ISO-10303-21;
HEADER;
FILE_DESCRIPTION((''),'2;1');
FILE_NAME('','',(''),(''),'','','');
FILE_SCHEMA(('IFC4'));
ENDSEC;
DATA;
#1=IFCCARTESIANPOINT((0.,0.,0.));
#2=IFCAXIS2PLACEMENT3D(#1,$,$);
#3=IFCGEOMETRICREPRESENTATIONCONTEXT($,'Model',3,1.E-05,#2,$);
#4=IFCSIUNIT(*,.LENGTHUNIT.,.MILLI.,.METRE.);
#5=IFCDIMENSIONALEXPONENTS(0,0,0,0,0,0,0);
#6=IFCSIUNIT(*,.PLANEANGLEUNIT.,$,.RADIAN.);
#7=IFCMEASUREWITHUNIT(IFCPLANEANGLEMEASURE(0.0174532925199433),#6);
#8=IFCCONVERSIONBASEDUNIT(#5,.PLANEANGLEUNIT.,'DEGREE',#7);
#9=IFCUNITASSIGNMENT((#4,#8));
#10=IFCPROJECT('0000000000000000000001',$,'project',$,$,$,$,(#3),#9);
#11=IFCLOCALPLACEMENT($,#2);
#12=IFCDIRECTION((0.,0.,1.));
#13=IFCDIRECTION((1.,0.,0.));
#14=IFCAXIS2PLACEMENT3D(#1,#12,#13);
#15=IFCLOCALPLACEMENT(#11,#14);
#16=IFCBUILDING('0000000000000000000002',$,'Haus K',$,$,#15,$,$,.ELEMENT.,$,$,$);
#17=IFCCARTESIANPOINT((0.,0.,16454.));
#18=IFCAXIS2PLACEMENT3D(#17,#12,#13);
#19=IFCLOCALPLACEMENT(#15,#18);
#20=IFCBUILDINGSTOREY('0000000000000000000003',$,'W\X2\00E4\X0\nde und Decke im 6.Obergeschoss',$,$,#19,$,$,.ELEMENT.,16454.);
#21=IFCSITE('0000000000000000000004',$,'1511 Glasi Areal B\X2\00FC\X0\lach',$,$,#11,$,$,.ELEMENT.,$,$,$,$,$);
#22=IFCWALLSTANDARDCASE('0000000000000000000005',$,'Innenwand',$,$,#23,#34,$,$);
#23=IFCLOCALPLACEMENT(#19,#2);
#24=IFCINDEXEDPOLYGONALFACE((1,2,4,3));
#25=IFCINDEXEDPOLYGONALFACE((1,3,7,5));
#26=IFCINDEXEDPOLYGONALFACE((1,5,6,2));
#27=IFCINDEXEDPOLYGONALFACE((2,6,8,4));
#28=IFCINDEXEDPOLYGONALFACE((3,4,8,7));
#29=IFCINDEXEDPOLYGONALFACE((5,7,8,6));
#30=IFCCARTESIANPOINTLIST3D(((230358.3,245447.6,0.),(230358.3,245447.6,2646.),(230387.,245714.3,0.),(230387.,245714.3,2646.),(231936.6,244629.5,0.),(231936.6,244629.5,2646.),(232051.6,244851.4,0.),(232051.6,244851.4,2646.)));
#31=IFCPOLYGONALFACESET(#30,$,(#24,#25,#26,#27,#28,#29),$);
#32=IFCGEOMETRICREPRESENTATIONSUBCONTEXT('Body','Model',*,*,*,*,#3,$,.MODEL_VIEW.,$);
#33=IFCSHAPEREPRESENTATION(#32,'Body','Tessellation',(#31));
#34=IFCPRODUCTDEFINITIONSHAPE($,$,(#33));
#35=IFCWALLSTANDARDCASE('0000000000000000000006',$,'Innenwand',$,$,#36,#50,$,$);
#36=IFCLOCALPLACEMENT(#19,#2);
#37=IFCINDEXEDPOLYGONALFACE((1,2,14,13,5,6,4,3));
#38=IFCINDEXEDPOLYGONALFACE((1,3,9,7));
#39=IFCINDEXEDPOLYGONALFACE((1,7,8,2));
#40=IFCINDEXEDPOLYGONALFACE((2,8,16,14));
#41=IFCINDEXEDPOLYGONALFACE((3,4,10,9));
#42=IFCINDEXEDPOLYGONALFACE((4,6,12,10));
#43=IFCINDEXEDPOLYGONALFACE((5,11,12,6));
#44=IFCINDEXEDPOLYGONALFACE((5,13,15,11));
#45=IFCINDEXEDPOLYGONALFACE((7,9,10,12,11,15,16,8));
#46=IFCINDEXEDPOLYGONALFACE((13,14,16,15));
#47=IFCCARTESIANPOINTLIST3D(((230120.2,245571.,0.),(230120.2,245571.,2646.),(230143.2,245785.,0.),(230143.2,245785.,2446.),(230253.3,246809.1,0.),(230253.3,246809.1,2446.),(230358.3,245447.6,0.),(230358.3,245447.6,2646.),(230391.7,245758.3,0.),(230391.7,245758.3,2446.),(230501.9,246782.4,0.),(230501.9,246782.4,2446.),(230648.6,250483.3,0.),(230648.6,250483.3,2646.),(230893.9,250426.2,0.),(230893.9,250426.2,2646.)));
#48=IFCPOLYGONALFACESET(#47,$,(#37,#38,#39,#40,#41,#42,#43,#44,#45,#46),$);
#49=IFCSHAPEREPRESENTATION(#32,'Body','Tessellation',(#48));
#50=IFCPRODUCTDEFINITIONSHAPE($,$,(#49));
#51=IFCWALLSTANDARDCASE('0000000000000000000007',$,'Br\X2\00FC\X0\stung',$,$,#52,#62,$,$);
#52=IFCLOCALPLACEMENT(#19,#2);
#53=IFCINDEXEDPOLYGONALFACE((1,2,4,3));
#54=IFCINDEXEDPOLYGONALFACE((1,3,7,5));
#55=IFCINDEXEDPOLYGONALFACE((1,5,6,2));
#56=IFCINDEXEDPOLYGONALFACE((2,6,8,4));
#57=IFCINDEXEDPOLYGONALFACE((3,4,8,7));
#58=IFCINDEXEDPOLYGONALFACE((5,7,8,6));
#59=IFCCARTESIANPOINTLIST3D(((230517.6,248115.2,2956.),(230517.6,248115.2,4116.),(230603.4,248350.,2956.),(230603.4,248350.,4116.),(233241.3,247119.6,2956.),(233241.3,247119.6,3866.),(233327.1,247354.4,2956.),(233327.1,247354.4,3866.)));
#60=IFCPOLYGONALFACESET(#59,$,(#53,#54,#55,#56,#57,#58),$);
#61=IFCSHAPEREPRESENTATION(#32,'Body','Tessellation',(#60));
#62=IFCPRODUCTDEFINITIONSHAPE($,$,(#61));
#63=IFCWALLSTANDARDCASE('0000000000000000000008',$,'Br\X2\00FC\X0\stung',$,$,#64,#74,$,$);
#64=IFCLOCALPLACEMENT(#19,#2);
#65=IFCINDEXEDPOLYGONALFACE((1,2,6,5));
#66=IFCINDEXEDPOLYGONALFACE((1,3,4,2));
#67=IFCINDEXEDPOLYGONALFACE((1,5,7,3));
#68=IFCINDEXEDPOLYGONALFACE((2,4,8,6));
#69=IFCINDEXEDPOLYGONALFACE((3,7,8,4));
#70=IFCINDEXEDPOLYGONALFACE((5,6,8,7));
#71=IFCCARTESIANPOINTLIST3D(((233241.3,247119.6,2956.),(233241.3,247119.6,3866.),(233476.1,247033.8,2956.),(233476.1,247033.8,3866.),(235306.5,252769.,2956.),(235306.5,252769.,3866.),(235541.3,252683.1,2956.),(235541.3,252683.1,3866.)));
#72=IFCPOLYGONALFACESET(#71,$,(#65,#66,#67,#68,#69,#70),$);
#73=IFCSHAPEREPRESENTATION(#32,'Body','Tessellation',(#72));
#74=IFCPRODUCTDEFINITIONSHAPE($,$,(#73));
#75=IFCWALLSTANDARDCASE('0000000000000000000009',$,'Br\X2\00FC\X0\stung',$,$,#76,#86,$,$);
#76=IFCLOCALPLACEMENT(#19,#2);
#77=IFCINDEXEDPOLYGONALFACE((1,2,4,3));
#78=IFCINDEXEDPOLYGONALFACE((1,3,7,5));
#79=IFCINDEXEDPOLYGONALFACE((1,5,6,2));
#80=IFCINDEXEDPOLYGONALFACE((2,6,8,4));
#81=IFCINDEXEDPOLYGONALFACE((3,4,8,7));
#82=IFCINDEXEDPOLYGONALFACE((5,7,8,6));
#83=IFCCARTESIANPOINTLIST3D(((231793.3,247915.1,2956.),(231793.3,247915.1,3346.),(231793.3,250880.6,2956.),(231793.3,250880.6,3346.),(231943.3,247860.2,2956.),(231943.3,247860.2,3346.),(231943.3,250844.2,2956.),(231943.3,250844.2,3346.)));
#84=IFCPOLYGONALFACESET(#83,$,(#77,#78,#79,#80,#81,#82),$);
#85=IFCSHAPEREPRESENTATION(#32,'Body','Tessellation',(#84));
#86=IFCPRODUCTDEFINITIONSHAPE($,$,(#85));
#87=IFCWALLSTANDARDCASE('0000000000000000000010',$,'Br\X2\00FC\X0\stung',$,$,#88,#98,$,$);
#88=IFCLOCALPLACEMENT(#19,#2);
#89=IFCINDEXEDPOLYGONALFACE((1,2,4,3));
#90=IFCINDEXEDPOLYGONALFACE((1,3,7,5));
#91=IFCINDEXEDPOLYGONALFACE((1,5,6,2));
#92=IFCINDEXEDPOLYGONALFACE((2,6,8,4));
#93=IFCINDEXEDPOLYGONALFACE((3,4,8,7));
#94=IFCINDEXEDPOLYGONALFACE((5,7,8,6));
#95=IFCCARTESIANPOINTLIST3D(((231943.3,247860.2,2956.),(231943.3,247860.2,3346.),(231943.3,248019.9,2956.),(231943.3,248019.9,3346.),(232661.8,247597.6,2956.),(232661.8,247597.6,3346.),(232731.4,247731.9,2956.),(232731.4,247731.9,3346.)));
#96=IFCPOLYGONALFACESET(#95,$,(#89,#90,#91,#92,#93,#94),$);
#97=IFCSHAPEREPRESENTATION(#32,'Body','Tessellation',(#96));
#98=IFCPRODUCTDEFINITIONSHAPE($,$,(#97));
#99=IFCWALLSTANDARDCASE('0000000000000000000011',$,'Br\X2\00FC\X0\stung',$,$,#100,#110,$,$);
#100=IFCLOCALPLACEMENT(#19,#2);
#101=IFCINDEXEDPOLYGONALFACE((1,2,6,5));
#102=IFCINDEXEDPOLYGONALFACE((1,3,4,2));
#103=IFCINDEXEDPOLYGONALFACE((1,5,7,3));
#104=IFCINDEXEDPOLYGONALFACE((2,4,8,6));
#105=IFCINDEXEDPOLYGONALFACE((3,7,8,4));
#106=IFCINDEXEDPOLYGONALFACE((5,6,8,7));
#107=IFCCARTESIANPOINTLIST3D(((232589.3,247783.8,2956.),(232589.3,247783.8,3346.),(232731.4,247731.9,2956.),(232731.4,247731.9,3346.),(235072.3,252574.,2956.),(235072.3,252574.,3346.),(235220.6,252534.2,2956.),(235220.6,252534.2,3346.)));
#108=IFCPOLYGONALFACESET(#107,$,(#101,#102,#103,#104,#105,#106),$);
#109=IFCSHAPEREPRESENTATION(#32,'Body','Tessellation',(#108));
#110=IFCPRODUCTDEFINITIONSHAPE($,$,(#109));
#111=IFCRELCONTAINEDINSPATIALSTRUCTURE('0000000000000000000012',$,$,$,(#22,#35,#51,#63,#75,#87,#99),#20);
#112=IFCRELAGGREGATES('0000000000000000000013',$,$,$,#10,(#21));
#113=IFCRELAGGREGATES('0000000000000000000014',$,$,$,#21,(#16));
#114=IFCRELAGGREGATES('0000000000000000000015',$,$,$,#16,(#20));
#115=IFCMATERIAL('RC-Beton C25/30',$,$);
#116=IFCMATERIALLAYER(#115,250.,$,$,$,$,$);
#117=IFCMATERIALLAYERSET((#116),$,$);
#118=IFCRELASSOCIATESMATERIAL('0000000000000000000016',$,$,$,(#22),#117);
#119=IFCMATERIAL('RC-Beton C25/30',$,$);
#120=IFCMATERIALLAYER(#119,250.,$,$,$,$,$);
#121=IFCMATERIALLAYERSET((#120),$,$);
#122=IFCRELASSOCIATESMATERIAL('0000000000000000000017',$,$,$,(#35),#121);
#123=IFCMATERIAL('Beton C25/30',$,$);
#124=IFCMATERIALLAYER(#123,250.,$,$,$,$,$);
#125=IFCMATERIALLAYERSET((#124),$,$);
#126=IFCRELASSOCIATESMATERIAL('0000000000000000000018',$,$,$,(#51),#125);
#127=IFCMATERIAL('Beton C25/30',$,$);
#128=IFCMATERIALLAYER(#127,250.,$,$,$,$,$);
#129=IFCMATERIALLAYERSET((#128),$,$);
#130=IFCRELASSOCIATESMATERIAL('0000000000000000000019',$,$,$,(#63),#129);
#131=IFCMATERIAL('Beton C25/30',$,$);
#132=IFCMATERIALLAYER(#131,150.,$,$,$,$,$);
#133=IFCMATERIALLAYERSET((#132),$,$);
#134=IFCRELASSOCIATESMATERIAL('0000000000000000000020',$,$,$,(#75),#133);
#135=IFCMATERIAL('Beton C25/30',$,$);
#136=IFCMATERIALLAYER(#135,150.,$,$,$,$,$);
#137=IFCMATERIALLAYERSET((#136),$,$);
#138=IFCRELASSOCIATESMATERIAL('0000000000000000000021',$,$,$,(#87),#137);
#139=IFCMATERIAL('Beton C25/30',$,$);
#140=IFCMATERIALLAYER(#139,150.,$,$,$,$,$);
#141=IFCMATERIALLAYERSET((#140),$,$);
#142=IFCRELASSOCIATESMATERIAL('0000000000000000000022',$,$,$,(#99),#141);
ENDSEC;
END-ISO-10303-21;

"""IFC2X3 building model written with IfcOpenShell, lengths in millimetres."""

from ifc_helpers import new_model, entity, si_unit, converted_unit, frame, frame_2d, origin, origin_with_axes, place, context, subcontext, project, spatial, polyline, rectangle, outline, extrude, clip, halfspace, material, layer, layer_set, layer_usage, element, save


model = new_model("IFC2X3")

# Units and contexts
model_context = context("Model", 3, precision=1e-05, world=origin())
body_context = subcontext(model_context, "Body", "Model", "MODEL_VIEW")
ifc_project = project(units=[si_unit("LENGTHUNIT", "METRE", prefix="MILLI"), converted_unit("PLANEANGLEUNIT", "DEGREE", entity("IfcPlaneAngleMeasure", 0.0174532925199433), si_unit("PLANEANGLEUNIT", "RADIAN"), dimensions=[0, 0, 0, 0, 0, 0, 0])], contexts=[model_context])

# Site, building, storey
site_placement = place(None, origin())
site = spatial("IfcSite", under=ifc_project, at=site_placement, Name="1511 Glasi Areal Bülach", CompositionType="ELEMENT")
building_placement = place(site_placement, origin_with_axes())
building = spatial("IfcBuilding", under=site, at=building_placement, Name="Haus K", CompositionType="ELEMENT")
storey_placement = place(building_placement, frame((0.0, 0.0, 16454.0), z_axis=(0.0, 0.0, 1.0), x_axis=(1.0, 0.0, 0.0)))
storey = spatial("IfcBuildingStorey", under=building, at=storey_placement, Name="Wände und Decke im 6.Obergeschoss", CompositionType="ELEMENT", Elevation=16454.0)

# Wall
ifc_material_1 = material(Name="RC-Beton C25/30")
ifc_layer_1 = layer(ifc_material_1, 250.0)
ifc_layer_set_1 = layer_set([ifc_layer_1])
ifc_layer_usage_1 = layer_usage(ifc_layer_set_1, "AXIS2", "POSITIVE", 0.0)
wall_1_placement = place(storey_placement, frame((232051.6, 244851.4, 0.0), z_axis=(0.0, 0.0, 1.0), x_axis=(-0.887815, 0.4602, 0.0)))
element("IfcWallStandardCase", 1, at=wall_1_placement, inside=storey, material=ifc_layer_usage_1, Name="Innenwand", context=body_context, shape_type="SweptSolid", body=[
    extrude(outline(polyline([(0.0, 0.0), (1874.9, 0.0), (1777.7, 250.0), (0.0, 250.0), (0.0, 0.0)])), origin_with_axes(), (0.0, 0.0, 1.0), 2646.0),
])

# Wall, opening
ifc_material_2 = material(Name="RC-Beton C25/30")
ifc_layer_2 = layer(ifc_material_2, 250.0)
ifc_layer_set_2 = layer_set([ifc_layer_2])
ifc_layer_usage_2 = layer_usage(ifc_layer_set_2, "AXIS2", "POSITIVE", 0.0)
wall_2_placement = place(storey_placement, frame((230358.3, 245447.6, 0.0), z_axis=(0.0, 0.0, 1.0), x_axis=(0.106958, 0.994264, 0.0)))
wall_2 = element("IfcWallStandardCase", 2, at=wall_2_placement, inside=storey, material=ifc_layer_usage_2, Name="Innenwand", context=body_context, shape_type="SweptSolid", body=[
    extrude(outline(polyline([(268.3, 0.0), (5007.4, 0.0), (5037.9, 250.0), (97.3, 250.0), (0.0, 0.0), (268.3, 0.0)])), origin_with_axes(), (0.0, 0.0, 1.0), 2646.0),
])
opening_1_placement = place(wall_2_placement, frame((312.5, 0.0, 0.0), z_axis=(0.0, 1.0, 0.0), x_axis=(0.0, 0.0, 1.0)))
element("IfcOpeningElement", 3, at=opening_1_placement, cuts=wall_2, ObjectType="Opening", context=body_context, shape_type="SweptSolid", body=[
    extrude(rectangle(XDim=2446.0, YDim=1030.0, at=frame_2d((1223.0, 515.0), x_axis=(1.0, 0.0))), origin_with_axes(), (0.0, 0.0, 1.0), 250.0),
])

# Walls
ifc_material_3 = material(Name="Beton C25/30")
ifc_layer_3 = layer(ifc_material_3, 250.0)
ifc_layer_set_3 = layer_set([ifc_layer_3])
ifc_layer_usage_3 = layer_usage(ifc_layer_set_3, "AXIS2", "POSITIVE", 0.0)
wall_3_placement = place(storey_placement, frame((230517.6, 248115.2, 2956.0), z_axis=(0.0, 0.0, 1.0), x_axis=(0.939214, -0.343332, 0.0)))
element("IfcWallStandardCase", 4, at=wall_3_placement, inside=storey, material=ifc_layer_usage_3, Name="Brüstung", context=body_context, shape_type="Clipping", body=[
    clip(extrude(rectangle(XDim=2900.0, YDim=250.0, at=frame_2d((1450.0, 125.0), x_axis=(1.0, 0.0))), origin_with_axes(), (0.0, 0.0, 1.0), 1160.0), halfspace(frame((0.0, 250.0, 1160.0), z_axis=(-0.085888, 0.0, -0.996305), x_axis=(0.0, -1.0, 0.0)), True)),
])
ifc_material_4 = material(Name="Beton C25/30")
ifc_layer_4 = layer(ifc_material_4, 250.0)
ifc_layer_set_4 = layer_set([ifc_layer_4])
ifc_layer_usage_4 = layer_usage(ifc_layer_set_4, "AXIS2", "POSITIVE", 0.0)
wall_4_placement = place(storey_placement, frame((233476.1, 247033.8, 2956.0), z_axis=(0.0, 0.0, 1.0), x_axis=(0.343332, 0.939214, 0.0)))
element("IfcWallStandardCase", 5, at=wall_4_placement, inside=storey, material=ifc_layer_usage_4, Name="Brüstung", context=body_context, shape_type="SweptSolid", body=[
    extrude(rectangle(XDim=6015.0, YDim=250.0, at=frame_2d((3007.5, 125.0), x_axis=(1.0, 0.0))), origin_with_axes(), (0.0, 0.0, 1.0), 910.0),
])
ifc_material_5 = material(Name="Beton C25/30")
ifc_layer_5 = layer(ifc_material_5, 150.0)
ifc_layer_set_5 = layer_set([ifc_layer_5])
ifc_layer_usage_5 = layer_usage(ifc_layer_set_5, "AXIS2", "POSITIVE", 0.0)
wall_5_placement = place(storey_placement, frame((231793.3, 250880.6, 2956.0), z_axis=(0.0, 0.0, 1.0), x_axis=(0.0, -1.0, 0.0)))
element("IfcWallStandardCase", 6, at=wall_5_placement, inside=storey, material=ifc_layer_usage_5, Name="Brüstung", context=body_context, shape_type="SweptSolid", body=[
    extrude(outline(polyline([(0.0, 0.0), (2965.5, 0.0), (3020.4, 150.0), (36.4, 150.0), (0.0, 0.0)])), origin_with_axes(), (0.0, 0.0, 1.0), 390.0),
])
ifc_material_6 = material(Name="Beton C25/30")
ifc_layer_6 = layer(ifc_material_6, 150.0)
ifc_layer_set_6 = layer_set([ifc_layer_6])
ifc_layer_usage_6 = layer_usage(ifc_layer_set_6, "AXIS2", "POSITIVE", 0.0)
wall_6_placement = place(storey_placement, frame((231943.3, 247860.2, 2956.0), z_axis=(0.0, 0.0, 1.0), x_axis=(0.939214, -0.343332, 0.0)))
element("IfcWallStandardCase", 7, at=wall_6_placement, inside=storey, material=ifc_layer_usage_6, Name="Brüstung", context=body_context, shape_type="SweptSolid", body=[
    extrude(outline(polyline([(0.0, 0.0), (764.9, 0.0), (784.2, 150.0), (-54.8, 150.0), (0.0, 0.0)])), origin_with_axes(), (0.0, 0.0, 1.0), 390.0),
])
ifc_material_7 = material(Name="Beton C25/30")
ifc_layer_7 = layer(ifc_material_7, 150.0)
ifc_layer_set_7 = layer_set([ifc_layer_7])
ifc_layer_usage_7 = layer_usage(ifc_layer_set_7, "AXIS2", "POSITIVE", 0.0)
wall_7_placement = place(storey_placement, frame((232731.4, 247731.9, 2956.0), z_axis=(0.0, 0.0, 1.0), x_axis=(0.4602, 0.887815, 0.0)))
element("IfcWallStandardCase", 8, at=wall_7_placement, inside=storey, material=ifc_layer_usage_7, Name="Brüstung", context=body_context, shape_type="SweptSolid", body=[
    extrude(outline(polyline([(0.0, 0.0), (5409.1, 0.0), (5376.2, 150.0), (-19.3, 150.0), (0.0, 0.0)])), origin_with_axes(), (0.0, 0.0, 1.0), 390.0),
])

save(model, "model.ifc")
